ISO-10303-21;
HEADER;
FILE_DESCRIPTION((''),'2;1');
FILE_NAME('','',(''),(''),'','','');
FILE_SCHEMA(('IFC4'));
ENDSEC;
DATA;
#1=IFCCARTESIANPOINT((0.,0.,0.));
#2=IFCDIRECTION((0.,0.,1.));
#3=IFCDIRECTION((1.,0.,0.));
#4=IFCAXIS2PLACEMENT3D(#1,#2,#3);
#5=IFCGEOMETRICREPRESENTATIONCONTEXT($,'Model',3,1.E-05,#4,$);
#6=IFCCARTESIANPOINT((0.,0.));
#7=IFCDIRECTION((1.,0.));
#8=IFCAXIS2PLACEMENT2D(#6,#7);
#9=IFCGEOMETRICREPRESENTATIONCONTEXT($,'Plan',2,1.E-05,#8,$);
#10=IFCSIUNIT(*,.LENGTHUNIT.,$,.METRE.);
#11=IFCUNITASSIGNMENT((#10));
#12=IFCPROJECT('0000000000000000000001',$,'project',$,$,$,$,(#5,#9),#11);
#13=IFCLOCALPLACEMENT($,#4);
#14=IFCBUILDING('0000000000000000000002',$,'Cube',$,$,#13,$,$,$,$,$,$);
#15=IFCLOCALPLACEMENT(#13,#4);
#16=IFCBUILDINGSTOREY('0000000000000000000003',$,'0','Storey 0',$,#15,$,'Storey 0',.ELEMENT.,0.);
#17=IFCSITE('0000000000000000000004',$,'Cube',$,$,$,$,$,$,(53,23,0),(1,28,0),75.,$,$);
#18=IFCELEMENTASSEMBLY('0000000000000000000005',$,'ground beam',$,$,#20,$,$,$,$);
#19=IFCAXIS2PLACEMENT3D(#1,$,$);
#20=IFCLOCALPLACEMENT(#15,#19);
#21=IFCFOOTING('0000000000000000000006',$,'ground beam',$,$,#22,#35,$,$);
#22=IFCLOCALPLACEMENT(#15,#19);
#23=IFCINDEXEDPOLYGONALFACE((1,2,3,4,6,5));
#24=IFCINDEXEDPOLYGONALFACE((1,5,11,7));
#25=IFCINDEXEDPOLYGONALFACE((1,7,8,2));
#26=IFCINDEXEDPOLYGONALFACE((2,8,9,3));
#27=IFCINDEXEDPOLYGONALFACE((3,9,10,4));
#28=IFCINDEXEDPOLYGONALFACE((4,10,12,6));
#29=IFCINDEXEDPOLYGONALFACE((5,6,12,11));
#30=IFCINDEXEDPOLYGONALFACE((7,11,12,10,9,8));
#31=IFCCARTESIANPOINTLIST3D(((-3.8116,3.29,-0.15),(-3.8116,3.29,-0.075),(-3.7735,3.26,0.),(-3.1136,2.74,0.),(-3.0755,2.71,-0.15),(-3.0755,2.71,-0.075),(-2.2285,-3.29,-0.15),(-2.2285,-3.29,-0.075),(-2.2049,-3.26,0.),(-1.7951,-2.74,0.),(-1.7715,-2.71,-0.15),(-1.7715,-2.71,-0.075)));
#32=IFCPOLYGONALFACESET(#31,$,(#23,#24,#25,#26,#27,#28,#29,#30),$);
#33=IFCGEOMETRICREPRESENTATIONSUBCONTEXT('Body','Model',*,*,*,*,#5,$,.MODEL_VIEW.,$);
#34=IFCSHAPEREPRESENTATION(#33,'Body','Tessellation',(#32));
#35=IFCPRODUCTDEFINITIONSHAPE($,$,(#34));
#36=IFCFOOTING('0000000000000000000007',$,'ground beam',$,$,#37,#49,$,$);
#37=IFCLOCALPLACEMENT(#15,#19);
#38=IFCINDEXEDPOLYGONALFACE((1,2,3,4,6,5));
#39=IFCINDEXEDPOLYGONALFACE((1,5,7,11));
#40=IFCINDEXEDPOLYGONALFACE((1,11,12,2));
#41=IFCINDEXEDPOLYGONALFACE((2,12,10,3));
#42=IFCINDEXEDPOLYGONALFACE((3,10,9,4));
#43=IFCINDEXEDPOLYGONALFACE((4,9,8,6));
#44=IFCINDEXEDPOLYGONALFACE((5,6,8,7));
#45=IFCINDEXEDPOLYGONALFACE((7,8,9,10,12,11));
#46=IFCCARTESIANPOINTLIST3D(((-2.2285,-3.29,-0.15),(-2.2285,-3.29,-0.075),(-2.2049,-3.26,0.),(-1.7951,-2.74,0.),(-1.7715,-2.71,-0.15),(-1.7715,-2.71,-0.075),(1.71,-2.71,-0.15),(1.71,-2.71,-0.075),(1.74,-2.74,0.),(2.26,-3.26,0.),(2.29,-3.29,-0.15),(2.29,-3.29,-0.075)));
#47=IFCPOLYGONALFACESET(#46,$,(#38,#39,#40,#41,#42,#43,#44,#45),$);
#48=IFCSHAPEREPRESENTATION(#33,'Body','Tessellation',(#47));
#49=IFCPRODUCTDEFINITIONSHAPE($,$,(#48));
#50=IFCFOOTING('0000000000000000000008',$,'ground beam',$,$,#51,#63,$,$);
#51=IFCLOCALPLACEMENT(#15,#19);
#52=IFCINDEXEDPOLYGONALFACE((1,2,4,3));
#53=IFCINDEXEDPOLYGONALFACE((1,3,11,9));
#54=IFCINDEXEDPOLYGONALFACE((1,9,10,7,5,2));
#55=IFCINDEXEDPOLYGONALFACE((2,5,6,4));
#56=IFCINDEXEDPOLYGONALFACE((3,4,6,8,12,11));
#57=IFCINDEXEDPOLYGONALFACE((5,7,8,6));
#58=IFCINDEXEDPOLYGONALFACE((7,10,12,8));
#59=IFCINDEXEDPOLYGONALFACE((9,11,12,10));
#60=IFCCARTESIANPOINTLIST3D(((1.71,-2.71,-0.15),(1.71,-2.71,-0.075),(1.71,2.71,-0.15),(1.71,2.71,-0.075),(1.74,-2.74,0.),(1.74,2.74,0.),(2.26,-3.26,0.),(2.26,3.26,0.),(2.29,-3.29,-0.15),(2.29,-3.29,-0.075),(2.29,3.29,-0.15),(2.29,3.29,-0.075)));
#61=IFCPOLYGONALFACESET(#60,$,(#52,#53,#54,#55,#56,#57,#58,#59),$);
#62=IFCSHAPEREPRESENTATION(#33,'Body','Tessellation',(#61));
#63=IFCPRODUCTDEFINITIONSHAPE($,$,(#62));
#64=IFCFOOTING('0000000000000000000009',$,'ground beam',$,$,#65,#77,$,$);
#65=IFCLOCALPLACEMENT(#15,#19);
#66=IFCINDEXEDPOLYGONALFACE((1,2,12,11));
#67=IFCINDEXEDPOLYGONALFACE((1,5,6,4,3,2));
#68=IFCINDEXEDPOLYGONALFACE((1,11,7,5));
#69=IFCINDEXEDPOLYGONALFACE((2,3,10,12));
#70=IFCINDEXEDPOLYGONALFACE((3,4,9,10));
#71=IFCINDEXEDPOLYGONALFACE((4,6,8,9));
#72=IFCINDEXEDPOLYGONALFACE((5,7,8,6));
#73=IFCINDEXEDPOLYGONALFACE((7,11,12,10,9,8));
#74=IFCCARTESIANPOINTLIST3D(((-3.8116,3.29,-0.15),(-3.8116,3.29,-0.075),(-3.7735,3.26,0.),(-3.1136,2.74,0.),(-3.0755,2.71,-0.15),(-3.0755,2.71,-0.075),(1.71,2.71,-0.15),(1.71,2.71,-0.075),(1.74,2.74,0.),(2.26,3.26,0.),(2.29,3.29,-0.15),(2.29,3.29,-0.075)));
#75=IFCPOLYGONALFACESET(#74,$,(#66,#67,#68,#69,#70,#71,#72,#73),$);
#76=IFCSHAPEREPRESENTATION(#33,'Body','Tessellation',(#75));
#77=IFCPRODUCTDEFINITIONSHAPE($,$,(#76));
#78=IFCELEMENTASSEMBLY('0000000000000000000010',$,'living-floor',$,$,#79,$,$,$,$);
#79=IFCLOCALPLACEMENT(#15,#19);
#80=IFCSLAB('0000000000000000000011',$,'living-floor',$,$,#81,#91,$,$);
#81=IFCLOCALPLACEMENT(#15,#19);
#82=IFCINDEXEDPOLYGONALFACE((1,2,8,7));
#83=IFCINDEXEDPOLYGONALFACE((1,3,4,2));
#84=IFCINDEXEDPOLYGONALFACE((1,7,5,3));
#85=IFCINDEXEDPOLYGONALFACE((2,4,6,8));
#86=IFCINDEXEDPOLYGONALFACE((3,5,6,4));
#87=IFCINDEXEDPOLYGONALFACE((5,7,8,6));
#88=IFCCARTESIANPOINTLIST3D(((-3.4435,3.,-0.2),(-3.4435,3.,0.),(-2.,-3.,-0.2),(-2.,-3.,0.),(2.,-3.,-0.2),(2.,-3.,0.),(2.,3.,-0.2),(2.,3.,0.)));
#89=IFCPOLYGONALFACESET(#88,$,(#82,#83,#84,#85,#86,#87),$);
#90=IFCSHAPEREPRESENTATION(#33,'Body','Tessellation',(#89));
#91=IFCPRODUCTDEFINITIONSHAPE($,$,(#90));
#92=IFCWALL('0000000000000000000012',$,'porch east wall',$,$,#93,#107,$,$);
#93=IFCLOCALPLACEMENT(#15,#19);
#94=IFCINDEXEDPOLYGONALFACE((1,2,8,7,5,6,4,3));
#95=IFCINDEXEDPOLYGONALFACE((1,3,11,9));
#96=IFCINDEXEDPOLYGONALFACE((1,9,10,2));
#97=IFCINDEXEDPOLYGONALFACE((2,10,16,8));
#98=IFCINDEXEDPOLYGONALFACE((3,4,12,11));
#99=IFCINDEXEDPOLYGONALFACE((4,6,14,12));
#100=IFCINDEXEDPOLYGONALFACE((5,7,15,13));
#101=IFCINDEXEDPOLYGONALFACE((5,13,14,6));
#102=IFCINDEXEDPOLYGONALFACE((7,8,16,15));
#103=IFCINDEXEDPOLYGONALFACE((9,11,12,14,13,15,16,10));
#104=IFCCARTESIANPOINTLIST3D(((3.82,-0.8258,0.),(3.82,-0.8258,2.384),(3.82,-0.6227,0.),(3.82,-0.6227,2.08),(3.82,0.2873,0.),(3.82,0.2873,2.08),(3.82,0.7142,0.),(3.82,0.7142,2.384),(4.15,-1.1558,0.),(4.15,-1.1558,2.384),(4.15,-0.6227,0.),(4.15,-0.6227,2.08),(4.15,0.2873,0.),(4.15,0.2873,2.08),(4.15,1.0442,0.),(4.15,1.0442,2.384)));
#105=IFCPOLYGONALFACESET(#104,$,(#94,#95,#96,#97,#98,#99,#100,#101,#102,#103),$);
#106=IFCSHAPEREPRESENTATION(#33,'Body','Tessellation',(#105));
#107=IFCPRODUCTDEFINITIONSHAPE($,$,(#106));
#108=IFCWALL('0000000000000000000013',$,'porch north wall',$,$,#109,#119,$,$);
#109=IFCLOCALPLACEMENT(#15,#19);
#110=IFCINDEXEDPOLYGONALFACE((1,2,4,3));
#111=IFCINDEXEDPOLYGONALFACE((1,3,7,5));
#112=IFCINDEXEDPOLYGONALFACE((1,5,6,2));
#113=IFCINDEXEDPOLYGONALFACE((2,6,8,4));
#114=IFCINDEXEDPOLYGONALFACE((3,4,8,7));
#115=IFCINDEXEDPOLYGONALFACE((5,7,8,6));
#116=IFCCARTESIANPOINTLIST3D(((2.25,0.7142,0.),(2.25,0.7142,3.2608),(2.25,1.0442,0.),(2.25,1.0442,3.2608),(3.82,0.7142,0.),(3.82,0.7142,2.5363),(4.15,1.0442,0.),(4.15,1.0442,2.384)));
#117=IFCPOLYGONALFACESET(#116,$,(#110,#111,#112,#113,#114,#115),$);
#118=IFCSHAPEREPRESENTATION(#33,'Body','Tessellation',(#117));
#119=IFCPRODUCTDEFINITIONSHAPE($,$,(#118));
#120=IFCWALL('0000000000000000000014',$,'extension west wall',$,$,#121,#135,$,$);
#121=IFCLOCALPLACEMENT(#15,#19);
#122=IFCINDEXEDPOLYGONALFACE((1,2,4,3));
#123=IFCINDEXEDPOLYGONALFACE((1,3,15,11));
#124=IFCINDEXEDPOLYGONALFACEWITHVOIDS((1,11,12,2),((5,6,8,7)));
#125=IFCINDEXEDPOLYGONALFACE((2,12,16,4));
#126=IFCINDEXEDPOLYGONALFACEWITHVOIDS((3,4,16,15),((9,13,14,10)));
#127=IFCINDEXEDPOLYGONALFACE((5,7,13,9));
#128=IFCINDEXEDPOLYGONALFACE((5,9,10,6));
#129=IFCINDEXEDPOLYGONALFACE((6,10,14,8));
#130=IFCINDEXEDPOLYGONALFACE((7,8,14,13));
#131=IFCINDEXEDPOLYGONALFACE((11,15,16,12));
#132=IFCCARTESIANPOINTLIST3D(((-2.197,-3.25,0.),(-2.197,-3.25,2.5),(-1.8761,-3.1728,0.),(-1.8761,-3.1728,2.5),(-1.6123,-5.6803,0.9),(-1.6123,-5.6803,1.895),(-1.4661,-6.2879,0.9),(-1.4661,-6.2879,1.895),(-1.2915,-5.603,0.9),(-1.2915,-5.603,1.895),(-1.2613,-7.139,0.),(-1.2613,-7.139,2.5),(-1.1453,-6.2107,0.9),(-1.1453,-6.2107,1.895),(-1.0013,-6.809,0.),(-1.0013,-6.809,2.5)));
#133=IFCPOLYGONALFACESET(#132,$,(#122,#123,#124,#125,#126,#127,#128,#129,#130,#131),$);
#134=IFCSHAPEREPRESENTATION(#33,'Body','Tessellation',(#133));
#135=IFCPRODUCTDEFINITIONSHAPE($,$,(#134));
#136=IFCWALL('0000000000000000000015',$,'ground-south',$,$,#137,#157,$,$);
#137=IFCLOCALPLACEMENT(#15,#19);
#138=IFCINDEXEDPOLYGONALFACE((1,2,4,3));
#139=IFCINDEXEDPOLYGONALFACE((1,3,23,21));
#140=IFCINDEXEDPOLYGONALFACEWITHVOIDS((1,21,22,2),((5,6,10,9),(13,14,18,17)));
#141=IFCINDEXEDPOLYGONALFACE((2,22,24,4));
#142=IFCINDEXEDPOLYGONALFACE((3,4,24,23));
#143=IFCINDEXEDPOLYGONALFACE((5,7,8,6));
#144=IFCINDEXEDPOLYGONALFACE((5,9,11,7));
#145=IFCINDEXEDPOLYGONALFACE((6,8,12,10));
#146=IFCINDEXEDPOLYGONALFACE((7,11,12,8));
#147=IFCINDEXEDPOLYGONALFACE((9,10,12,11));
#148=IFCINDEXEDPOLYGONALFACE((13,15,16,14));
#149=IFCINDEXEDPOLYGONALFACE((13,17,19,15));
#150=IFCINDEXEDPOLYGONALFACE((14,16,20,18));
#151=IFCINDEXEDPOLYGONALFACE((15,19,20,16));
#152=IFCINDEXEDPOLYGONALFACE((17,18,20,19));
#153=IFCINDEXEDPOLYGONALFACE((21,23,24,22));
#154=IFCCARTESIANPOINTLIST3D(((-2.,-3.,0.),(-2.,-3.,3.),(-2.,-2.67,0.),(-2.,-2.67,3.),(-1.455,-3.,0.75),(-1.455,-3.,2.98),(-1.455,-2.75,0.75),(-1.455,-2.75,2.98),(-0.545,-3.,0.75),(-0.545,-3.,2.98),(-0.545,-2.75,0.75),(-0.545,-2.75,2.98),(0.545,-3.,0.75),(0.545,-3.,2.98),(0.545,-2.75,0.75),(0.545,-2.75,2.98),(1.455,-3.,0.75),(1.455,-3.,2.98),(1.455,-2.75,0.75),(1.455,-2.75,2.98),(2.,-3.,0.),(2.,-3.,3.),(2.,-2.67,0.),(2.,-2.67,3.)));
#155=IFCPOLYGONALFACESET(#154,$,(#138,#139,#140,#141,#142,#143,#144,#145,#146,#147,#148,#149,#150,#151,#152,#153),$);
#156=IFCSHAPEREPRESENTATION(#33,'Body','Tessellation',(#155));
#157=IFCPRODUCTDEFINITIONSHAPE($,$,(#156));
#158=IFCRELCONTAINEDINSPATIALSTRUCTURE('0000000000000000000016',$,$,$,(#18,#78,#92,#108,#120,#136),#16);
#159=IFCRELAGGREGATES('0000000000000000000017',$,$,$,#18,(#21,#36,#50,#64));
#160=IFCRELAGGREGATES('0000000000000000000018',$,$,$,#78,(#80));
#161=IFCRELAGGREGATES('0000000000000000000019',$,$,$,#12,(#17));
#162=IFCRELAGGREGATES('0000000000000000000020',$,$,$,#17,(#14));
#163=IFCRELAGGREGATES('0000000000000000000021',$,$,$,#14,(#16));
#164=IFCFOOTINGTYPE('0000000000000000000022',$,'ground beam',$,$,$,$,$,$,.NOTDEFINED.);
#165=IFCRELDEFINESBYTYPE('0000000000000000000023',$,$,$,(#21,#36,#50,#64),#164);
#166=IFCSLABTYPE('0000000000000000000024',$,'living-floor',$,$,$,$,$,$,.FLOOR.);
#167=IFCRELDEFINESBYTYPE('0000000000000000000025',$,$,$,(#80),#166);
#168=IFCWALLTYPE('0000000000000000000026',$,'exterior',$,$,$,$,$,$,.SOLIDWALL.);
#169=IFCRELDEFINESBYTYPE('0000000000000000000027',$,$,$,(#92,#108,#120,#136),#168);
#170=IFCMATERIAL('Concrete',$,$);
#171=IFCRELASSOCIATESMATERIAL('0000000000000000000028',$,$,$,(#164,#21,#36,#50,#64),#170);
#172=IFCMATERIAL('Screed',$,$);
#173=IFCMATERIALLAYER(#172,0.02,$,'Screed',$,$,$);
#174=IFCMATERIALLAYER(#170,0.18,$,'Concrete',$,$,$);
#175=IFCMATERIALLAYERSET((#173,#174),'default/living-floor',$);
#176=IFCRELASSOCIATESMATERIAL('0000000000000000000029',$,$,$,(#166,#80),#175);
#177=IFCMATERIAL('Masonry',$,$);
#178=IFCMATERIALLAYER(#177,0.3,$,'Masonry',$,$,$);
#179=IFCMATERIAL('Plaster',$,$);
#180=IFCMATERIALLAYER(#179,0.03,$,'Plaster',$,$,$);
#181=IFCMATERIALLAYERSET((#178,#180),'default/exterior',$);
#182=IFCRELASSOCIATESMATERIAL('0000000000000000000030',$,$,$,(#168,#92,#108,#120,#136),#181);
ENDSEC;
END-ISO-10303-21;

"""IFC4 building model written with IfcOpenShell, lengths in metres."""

from ifc_helpers import new_model, si_unit, frame, origin, origin_with_axes, origin_2d_with_axis, place, context, subcontext, project, spatial, polyline, line, indexed_curve, outline, extrude, clip, halfspace, source, transform, mapped, material, layer, layer_set, layer_usage, material_profile, profile_set, profile_usage, type_object, element, aggregate, save


model = new_model("IFC4")

# Units and contexts
model_context = context("Model", 3, precision=1e-05, world=origin_with_axes())
plan_context = context("Plan", 2, precision=1e-05, world=origin_2d_with_axis())
body_context = subcontext(model_context, "Body", "Model", "MODEL_VIEW")
ifc_project = project(units=[si_unit("LENGTHUNIT", "METRE")], contexts=[model_context, plan_context])

# Site, building, storey
site = spatial("IfcSite", under=ifc_project, Name="Cube", RefLatitude=(53, 23, 0), RefLongitude=(1, 28, 0), RefElevation=75.0)
building_placement = place(None, origin_with_axes())
building = spatial("IfcBuilding", under=site, at=building_placement, Name="Cube")
storey_placement = place(building_placement, origin_with_axes())
storey = spatial("IfcBuildingStorey", under=building, at=storey_placement, Name="0", Description="Storey 0", LongName="Storey 0", CompositionType="ELEMENT", Elevation=0.0)

# Element assembly, footings
assembly_1_placement = place(storey_placement, origin_with_axes())
assembly_1 = element("IfcElementAssembly", 1, at=assembly_1_placement, inside=storey, Name="ground beam")
ifc_material_1 = material(Name="Concrete")
ifc_material_profile = material_profile(ifc_material_1, outline(polyline([(-0.26, 0.0), (-0.29, -0.075), (-0.29, -0.15), (0.29, -0.15), (0.29, -0.075), (0.26, 0.0), (-0.26, 0.0)])))
ifc_profile_set = profile_set([ifc_material_profile])
ifc_profile_usage_1 = profile_usage(ifc_profile_set)
footing_type = type_object("IfcFootingType", Name="ground beam", PredefinedType="NOTDEFINED", material=ifc_profile_set)
footing_1_placement = place(assembly_1_placement, frame((-1.7661, -3.9723, 0.0), z_axis=(-0.233915, 0.972257, 0.0), x_axis=(-0.972257, -0.233915, 0.0)))
footing_1 = element("IfcFooting", 2, at=footing_1_placement, type_object=footing_type, material=ifc_profile_usage_1, Name="ground beam", context=body_context, shape_type="Clipping", body=[
    clip(clip(extrude(outline(polyline([(-0.26, 0.0), (-0.29, -0.075), (-0.29, -0.15), (0.29, -0.15), (0.29, -0.075), (0.26, 0.0), (-0.26, 0.0)])), origin_with_axes(), (0.0, 0.0, 1.0), 8.1712), halfspace(frame((0.0, 0.0, 1.0), z_axis=(-0.618904, 0.0, -0.785467), x_axis=(0.0, 1.0, 0.0)), False)), halfspace(frame((0.0, 0.0, 7.1712), z_axis=(-0.785467, 0.0, 0.618904), x_axis=(0.0, 1.0, 0.0)), False)),
])
ifc_profile_usage_2 = profile_usage(ifc_profile_set)
footing_2_placement = place(assembly_1_placement, frame((3.0, -3.0, 0.0), z_axis=(-1.0, 0.0, 0.0), x_axis=(0.0, -1.0, 0.0)))
footing_2 = element("IfcFooting", 3, at=footing_2_placement, type_object=footing_type, material=ifc_profile_usage_2, Name="ground beam", context=body_context, shape_type="Clipping", body=[
    clip(clip(extrude(outline(polyline([(-0.26, 0.0), (-0.29, -0.075), (-0.29, -0.15), (0.29, -0.15), (0.29, -0.075), (0.26, 0.0), (-0.26, 0.0)])), origin_with_axes(), (0.0, 0.0, 1.0), 6.0), halfspace(frame((0.0, 0.0, 1.0), z_axis=(-0.707107, 0.0, -0.707107), x_axis=(0.0, 1.0, 0.0)), False)), halfspace(frame((0.0, 0.0, 5.0), z_axis=(-0.618904, 0.0, 0.785467), x_axis=(0.0, 1.0, 0.0)), False)),
])
ifc_profile_usage_3 = profile_usage(ifc_profile_set)
footing_3_placement = place(assembly_1_placement, frame((2.0, 4.0, 0.0), z_axis=(0.0, -1.0, 0.0), x_axis=(1.0, 0.0, 0.0)))
footing_3 = element("IfcFooting", 4, at=footing_3_placement, type_object=footing_type, material=ifc_profile_usage_3, Name="ground beam", context=body_context, shape_type="Clipping", body=[
    clip(clip(extrude(outline(polyline([(-0.26, 0.0), (-0.29, -0.075), (-0.29, -0.15), (0.29, -0.15), (0.29, -0.075), (0.26, 0.0), (-0.26, 0.0)])), origin_with_axes(), (0.0, 0.0, 1.0), 8.0), halfspace(frame((0.0, 0.0, 1.0), z_axis=(-0.707107, 0.0, -0.707107), x_axis=(0.0, 1.0, 0.0)), False)), halfspace(frame((0.0, 0.0, 7.0), z_axis=(-0.707107, 0.0, 0.707107), x_axis=(0.0, 1.0, 0.0)), False)),
])
ifc_profile_usage_4 = profile_usage(ifc_profile_set)
footing_4_placement = place(assembly_1_placement, frame((-4.4435, 3.0, 0.0), z_axis=(1.0, 0.0, 0.0), x_axis=(0.0, 1.0, 0.0)))
footing_4 = element("IfcFooting", 5, at=footing_4_placement, type_object=footing_type, material=ifc_profile_usage_4, Name="ground beam", context=body_context, shape_type="Clipping", body=[
    clip(clip(extrude(outline(polyline([(-0.26, 0.0), (-0.29, -0.075), (-0.29, -0.15), (0.29, -0.15), (0.29, -0.075), (0.26, 0.0), (-0.26, 0.0)])), origin_with_axes(), (0.0, 0.0, 1.0), 7.4435), halfspace(frame((0.0, 0.0, 1.0), z_axis=(-0.785467, 0.0, -0.618904), x_axis=(0.0, 1.0, 0.0)), False)), halfspace(frame((0.0, 0.0, 6.4435), z_axis=(-0.707107, 0.0, 0.707107), x_axis=(0.0, 1.0, 0.0)), False)),
])
aggregate(assembly_1, [footing_1, footing_2, footing_3, footing_4])

# Element assembly, slab
assembly_2_placement = place(storey_placement, origin_with_axes())
assembly_2 = element("IfcElementAssembly", 6, at=assembly_2_placement, inside=storey, Name="living-floor")
ifc_material_2 = material(Name="Screed")
ifc_layer_1 = layer(ifc_material_2, 0.02, Name="Screed")
ifc_layer_2 = layer(ifc_material_1, 0.18, Name="Concrete")
ifc_layer_set_1 = layer_set([ifc_layer_1, ifc_layer_2], Name="default/living-floor")
ifc_layer_usage_1 = layer_usage(ifc_layer_set_1, "AXIS3", "POSITIVE", 0.0)
slab_type = type_object("IfcSlabType", Name="living-floor", PredefinedType="FLOOR", material=ifc_layer_set_1)
slab_placement = place(assembly_2_placement, frame((2.0, 3.0, -0.2), z_axis=(0.0, 0.0, -1.0), x_axis=(0.0, 1.0, 0.0)))
slab = element("IfcSlab", 7, at=slab_placement, type_object=slab_type, material=ifc_layer_usage_1, Name="living-floor", context=body_context, shape_type="SweptSolid", body=[
    extrude(outline(polyline([(0.0, 0.0), (-6.0, 0.0), (-6.0, -4.0), (0.0, -5.4435), (0.0, 0.0)])), origin(), (0.0, 0.0, -1.0), 0.2),
])
aggregate(assembly_2, [slab])

# Wall, opening
ifc_material_3 = material(Name="Masonry")
ifc_layer_3 = layer(ifc_material_3, 0.3, Name="Masonry")
ifc_material_4 = material(Name="Plaster")
ifc_layer_4 = layer(ifc_material_4, 0.03, Name="Plaster")
ifc_layer_set_2 = layer_set([ifc_layer_3, ifc_layer_4], Name="default/exterior")
wall_type = type_object("IfcWallType", Name="exterior", PredefinedType="SOLIDWALL", material=ifc_layer_set_2)
ifc_layer_usage_2 = layer_usage(ifc_layer_set_2, "AXIS2", "POSITIVE", 0.0)
wall_1_placement = place(storey_placement, frame((4.15, -1.1558, 0.0), z_axis=(0.0, 0.0, 1.0), x_axis=(0.0, 1.0, 0.0)))
wall_1 = element("IfcWall", 8, at=wall_1_placement, inside=storey, type_object=wall_type, material=ifc_layer_usage_2, Name="porch east wall", context=body_context, shape_type="SweptSolid", body=[
    extrude(outline(indexed_curve([(0.0, 0.0), (0.33, 0.33), (1.87, 0.33), (2.2, 0.0)], segments=[line(1, 2, 3, 4, 1)])), origin_with_axes(), (0.0, 0.0, 1.0), 2.384),
])
shared_shape = source(origin_with_axes(), body_context, "Body", "SweptSolid", [
    extrude(outline(indexed_curve([(0.0, 0.0), (0.91, 0.0), (0.91, 2.08), (0.0, 2.08)], segments=[line(1, 2, 3, 4, 1)])), frame((0.0, -0.6, 0.0), z_axis=(0.0, -1.0, 0.0), x_axis=(1.0, 0.0, 0.0)), (0.0, 0.0, -1.0), 1.2),
])
opening_1_placement = place(wall_1_placement, frame((0.5331, 0.0, 0.0), z_axis=(0.0, 0.0, 1.0), x_axis=(1.0, 0.0, 0.0)))
element("IfcOpeningElement", 9, at=opening_1_placement, cuts=wall_1, PredefinedType="OPENING", context=body_context, shape_type="MappedRepresentation", body=[
    mapped(shared_shape, transform((0.0, 0.0, 0.0), x_axis=(1.0, 0.0, 0.0), y_axis=(0.0, 1.0, 0.0), z_axis=(0.0, 0.0, 1.0), scale=1.0)),
])

# Wall
ifc_layer_usage_3 = layer_usage(ifc_layer_set_2, "AXIS2", "POSITIVE", 0.0)
wall_2_placement = place(storey_placement, frame((4.15, 1.0442, 0.0), z_axis=(0.0, 0.0, 1.0), x_axis=(-1.0, 0.0, 0.0)))
element("IfcWall", 10, at=wall_2_placement, inside=storey, type_object=wall_type, material=ifc_layer_usage_3, Name="porch north wall", context=body_context, shape_type="Clipping", body=[
    clip(extrude(outline(indexed_curve([(0.0, 0.0), (1.9, 0.0), (1.9, 0.33), (0.33, 0.33)], segments=[line(1, 2, 3, 4, 1)])), origin_with_axes(), (0.0, 0.0, 1.0), 3.5), halfspace(frame((0.0, 0.0, 2.384), z_axis=(-0.419, 0.0, 0.908), x_axis=(0.0, 1.0, 0.0)), False)),
])

# Wall, opening
ifc_layer_usage_4 = layer_usage(ifc_layer_set_2, "AXIS2", "POSITIVE", 0.0)
wall_3_placement = place(storey_placement, frame((-2.197, -3.25, 0.0), z_axis=(0.0, 0.0, 1.0), x_axis=(0.233916, -0.972257, 0.0)))
wall_3 = element("IfcWall", 11, at=wall_3_placement, inside=storey, type_object=wall_type, material=ifc_layer_usage_4, Name="extension west wall", context=body_context, shape_type="SweptSolid", body=[
    extrude(outline(indexed_curve([(0.0, 0.0), (0.0, 0.33), (3.7399, 0.33), (4.0, 0.0)], segments=[line(1, 2, 3, 4, 1)])), origin_with_axes(), (0.0, 0.0, 1.0), 2.5),
])
opening_2_placement = place(wall_3_placement, frame((2.4996, -0.0501, 0.9), z_axis=(0.0, 0.0, 1.0), x_axis=(1.0, 0.000142, 0.0)))
element("IfcOpeningElement", 12, at=opening_2_placement, cuts=wall_3, PredefinedType="OPENING", context=body_context, shape_type="SweptSolid", body=[
    extrude(outline(indexed_curve([(0.0, 0.0), (0.0, 0.43), (0.625, 0.43), (0.625, 0.0), (0.0, 0.0)], self_intersect=False)), origin_with_axes(), (0.0, 0.0, 1.0), 0.995),
])

# Wall, openings
ifc_layer_usage_5 = layer_usage(ifc_layer_set_2, "AXIS2", "POSITIVE", 0.0)
wall_4_placement = place(storey_placement, frame((-2.0, -3.0, 0.0), z_axis=(0.0, 0.0, 1.0), x_axis=(1.0, 0.0, 0.0)))
wall_4 = element("IfcWall", 13, at=wall_4_placement, inside=storey, type_object=wall_type, material=ifc_layer_usage_5, Name="ground-south", context=body_context, shape_type="SweptSolid", body=[
    extrude(outline(indexed_curve([(0.0, 0.0), (4.0, 0.0), (4.0, 0.33), (0.0, 0.33)], segments=[line(1, 2, 3, 4, 1)])), origin_with_axes(), (0.0, 0.0, 1.0), 3.0),
])
opening_3_placement = place(wall_4_placement, frame((0.545, -0.25, 0.75), z_axis=(0.0, 0.0, 1.0), x_axis=(1.0, 0.0, 0.0)))
element("IfcOpeningElement", 14, at=opening_3_placement, cuts=wall_4, PredefinedType="OPENING", context=body_context, shape_type="SweptSolid", body=[
    extrude(outline(indexed_curve([(0.0, 0.0), (0.0, 0.5), (0.91, 0.5), (0.91, 0.0), (0.0, 0.0)], self_intersect=False)), origin_with_axes(), (0.0, 0.0, 1.0), 2.23),
])
opening_4_placement = place(wall_4_placement, frame((2.545, -0.25, 0.75), z_axis=(0.0, 0.0, 1.0), x_axis=(1.0, 0.0, 0.0)))
element("IfcOpeningElement", 15, at=opening_4_placement, cuts=wall_4, PredefinedType="OPENING", context=body_context, shape_type="SweptSolid", body=[
    extrude(outline(indexed_curve([(0.0, 0.0), (0.0, 0.5), (0.91, 0.5), (0.91, 0.0), (0.0, 0.0)], self_intersect=False)), origin_with_axes(), (0.0, 0.0, 1.0), 2.23),
])

save(model, "model.ifc")
